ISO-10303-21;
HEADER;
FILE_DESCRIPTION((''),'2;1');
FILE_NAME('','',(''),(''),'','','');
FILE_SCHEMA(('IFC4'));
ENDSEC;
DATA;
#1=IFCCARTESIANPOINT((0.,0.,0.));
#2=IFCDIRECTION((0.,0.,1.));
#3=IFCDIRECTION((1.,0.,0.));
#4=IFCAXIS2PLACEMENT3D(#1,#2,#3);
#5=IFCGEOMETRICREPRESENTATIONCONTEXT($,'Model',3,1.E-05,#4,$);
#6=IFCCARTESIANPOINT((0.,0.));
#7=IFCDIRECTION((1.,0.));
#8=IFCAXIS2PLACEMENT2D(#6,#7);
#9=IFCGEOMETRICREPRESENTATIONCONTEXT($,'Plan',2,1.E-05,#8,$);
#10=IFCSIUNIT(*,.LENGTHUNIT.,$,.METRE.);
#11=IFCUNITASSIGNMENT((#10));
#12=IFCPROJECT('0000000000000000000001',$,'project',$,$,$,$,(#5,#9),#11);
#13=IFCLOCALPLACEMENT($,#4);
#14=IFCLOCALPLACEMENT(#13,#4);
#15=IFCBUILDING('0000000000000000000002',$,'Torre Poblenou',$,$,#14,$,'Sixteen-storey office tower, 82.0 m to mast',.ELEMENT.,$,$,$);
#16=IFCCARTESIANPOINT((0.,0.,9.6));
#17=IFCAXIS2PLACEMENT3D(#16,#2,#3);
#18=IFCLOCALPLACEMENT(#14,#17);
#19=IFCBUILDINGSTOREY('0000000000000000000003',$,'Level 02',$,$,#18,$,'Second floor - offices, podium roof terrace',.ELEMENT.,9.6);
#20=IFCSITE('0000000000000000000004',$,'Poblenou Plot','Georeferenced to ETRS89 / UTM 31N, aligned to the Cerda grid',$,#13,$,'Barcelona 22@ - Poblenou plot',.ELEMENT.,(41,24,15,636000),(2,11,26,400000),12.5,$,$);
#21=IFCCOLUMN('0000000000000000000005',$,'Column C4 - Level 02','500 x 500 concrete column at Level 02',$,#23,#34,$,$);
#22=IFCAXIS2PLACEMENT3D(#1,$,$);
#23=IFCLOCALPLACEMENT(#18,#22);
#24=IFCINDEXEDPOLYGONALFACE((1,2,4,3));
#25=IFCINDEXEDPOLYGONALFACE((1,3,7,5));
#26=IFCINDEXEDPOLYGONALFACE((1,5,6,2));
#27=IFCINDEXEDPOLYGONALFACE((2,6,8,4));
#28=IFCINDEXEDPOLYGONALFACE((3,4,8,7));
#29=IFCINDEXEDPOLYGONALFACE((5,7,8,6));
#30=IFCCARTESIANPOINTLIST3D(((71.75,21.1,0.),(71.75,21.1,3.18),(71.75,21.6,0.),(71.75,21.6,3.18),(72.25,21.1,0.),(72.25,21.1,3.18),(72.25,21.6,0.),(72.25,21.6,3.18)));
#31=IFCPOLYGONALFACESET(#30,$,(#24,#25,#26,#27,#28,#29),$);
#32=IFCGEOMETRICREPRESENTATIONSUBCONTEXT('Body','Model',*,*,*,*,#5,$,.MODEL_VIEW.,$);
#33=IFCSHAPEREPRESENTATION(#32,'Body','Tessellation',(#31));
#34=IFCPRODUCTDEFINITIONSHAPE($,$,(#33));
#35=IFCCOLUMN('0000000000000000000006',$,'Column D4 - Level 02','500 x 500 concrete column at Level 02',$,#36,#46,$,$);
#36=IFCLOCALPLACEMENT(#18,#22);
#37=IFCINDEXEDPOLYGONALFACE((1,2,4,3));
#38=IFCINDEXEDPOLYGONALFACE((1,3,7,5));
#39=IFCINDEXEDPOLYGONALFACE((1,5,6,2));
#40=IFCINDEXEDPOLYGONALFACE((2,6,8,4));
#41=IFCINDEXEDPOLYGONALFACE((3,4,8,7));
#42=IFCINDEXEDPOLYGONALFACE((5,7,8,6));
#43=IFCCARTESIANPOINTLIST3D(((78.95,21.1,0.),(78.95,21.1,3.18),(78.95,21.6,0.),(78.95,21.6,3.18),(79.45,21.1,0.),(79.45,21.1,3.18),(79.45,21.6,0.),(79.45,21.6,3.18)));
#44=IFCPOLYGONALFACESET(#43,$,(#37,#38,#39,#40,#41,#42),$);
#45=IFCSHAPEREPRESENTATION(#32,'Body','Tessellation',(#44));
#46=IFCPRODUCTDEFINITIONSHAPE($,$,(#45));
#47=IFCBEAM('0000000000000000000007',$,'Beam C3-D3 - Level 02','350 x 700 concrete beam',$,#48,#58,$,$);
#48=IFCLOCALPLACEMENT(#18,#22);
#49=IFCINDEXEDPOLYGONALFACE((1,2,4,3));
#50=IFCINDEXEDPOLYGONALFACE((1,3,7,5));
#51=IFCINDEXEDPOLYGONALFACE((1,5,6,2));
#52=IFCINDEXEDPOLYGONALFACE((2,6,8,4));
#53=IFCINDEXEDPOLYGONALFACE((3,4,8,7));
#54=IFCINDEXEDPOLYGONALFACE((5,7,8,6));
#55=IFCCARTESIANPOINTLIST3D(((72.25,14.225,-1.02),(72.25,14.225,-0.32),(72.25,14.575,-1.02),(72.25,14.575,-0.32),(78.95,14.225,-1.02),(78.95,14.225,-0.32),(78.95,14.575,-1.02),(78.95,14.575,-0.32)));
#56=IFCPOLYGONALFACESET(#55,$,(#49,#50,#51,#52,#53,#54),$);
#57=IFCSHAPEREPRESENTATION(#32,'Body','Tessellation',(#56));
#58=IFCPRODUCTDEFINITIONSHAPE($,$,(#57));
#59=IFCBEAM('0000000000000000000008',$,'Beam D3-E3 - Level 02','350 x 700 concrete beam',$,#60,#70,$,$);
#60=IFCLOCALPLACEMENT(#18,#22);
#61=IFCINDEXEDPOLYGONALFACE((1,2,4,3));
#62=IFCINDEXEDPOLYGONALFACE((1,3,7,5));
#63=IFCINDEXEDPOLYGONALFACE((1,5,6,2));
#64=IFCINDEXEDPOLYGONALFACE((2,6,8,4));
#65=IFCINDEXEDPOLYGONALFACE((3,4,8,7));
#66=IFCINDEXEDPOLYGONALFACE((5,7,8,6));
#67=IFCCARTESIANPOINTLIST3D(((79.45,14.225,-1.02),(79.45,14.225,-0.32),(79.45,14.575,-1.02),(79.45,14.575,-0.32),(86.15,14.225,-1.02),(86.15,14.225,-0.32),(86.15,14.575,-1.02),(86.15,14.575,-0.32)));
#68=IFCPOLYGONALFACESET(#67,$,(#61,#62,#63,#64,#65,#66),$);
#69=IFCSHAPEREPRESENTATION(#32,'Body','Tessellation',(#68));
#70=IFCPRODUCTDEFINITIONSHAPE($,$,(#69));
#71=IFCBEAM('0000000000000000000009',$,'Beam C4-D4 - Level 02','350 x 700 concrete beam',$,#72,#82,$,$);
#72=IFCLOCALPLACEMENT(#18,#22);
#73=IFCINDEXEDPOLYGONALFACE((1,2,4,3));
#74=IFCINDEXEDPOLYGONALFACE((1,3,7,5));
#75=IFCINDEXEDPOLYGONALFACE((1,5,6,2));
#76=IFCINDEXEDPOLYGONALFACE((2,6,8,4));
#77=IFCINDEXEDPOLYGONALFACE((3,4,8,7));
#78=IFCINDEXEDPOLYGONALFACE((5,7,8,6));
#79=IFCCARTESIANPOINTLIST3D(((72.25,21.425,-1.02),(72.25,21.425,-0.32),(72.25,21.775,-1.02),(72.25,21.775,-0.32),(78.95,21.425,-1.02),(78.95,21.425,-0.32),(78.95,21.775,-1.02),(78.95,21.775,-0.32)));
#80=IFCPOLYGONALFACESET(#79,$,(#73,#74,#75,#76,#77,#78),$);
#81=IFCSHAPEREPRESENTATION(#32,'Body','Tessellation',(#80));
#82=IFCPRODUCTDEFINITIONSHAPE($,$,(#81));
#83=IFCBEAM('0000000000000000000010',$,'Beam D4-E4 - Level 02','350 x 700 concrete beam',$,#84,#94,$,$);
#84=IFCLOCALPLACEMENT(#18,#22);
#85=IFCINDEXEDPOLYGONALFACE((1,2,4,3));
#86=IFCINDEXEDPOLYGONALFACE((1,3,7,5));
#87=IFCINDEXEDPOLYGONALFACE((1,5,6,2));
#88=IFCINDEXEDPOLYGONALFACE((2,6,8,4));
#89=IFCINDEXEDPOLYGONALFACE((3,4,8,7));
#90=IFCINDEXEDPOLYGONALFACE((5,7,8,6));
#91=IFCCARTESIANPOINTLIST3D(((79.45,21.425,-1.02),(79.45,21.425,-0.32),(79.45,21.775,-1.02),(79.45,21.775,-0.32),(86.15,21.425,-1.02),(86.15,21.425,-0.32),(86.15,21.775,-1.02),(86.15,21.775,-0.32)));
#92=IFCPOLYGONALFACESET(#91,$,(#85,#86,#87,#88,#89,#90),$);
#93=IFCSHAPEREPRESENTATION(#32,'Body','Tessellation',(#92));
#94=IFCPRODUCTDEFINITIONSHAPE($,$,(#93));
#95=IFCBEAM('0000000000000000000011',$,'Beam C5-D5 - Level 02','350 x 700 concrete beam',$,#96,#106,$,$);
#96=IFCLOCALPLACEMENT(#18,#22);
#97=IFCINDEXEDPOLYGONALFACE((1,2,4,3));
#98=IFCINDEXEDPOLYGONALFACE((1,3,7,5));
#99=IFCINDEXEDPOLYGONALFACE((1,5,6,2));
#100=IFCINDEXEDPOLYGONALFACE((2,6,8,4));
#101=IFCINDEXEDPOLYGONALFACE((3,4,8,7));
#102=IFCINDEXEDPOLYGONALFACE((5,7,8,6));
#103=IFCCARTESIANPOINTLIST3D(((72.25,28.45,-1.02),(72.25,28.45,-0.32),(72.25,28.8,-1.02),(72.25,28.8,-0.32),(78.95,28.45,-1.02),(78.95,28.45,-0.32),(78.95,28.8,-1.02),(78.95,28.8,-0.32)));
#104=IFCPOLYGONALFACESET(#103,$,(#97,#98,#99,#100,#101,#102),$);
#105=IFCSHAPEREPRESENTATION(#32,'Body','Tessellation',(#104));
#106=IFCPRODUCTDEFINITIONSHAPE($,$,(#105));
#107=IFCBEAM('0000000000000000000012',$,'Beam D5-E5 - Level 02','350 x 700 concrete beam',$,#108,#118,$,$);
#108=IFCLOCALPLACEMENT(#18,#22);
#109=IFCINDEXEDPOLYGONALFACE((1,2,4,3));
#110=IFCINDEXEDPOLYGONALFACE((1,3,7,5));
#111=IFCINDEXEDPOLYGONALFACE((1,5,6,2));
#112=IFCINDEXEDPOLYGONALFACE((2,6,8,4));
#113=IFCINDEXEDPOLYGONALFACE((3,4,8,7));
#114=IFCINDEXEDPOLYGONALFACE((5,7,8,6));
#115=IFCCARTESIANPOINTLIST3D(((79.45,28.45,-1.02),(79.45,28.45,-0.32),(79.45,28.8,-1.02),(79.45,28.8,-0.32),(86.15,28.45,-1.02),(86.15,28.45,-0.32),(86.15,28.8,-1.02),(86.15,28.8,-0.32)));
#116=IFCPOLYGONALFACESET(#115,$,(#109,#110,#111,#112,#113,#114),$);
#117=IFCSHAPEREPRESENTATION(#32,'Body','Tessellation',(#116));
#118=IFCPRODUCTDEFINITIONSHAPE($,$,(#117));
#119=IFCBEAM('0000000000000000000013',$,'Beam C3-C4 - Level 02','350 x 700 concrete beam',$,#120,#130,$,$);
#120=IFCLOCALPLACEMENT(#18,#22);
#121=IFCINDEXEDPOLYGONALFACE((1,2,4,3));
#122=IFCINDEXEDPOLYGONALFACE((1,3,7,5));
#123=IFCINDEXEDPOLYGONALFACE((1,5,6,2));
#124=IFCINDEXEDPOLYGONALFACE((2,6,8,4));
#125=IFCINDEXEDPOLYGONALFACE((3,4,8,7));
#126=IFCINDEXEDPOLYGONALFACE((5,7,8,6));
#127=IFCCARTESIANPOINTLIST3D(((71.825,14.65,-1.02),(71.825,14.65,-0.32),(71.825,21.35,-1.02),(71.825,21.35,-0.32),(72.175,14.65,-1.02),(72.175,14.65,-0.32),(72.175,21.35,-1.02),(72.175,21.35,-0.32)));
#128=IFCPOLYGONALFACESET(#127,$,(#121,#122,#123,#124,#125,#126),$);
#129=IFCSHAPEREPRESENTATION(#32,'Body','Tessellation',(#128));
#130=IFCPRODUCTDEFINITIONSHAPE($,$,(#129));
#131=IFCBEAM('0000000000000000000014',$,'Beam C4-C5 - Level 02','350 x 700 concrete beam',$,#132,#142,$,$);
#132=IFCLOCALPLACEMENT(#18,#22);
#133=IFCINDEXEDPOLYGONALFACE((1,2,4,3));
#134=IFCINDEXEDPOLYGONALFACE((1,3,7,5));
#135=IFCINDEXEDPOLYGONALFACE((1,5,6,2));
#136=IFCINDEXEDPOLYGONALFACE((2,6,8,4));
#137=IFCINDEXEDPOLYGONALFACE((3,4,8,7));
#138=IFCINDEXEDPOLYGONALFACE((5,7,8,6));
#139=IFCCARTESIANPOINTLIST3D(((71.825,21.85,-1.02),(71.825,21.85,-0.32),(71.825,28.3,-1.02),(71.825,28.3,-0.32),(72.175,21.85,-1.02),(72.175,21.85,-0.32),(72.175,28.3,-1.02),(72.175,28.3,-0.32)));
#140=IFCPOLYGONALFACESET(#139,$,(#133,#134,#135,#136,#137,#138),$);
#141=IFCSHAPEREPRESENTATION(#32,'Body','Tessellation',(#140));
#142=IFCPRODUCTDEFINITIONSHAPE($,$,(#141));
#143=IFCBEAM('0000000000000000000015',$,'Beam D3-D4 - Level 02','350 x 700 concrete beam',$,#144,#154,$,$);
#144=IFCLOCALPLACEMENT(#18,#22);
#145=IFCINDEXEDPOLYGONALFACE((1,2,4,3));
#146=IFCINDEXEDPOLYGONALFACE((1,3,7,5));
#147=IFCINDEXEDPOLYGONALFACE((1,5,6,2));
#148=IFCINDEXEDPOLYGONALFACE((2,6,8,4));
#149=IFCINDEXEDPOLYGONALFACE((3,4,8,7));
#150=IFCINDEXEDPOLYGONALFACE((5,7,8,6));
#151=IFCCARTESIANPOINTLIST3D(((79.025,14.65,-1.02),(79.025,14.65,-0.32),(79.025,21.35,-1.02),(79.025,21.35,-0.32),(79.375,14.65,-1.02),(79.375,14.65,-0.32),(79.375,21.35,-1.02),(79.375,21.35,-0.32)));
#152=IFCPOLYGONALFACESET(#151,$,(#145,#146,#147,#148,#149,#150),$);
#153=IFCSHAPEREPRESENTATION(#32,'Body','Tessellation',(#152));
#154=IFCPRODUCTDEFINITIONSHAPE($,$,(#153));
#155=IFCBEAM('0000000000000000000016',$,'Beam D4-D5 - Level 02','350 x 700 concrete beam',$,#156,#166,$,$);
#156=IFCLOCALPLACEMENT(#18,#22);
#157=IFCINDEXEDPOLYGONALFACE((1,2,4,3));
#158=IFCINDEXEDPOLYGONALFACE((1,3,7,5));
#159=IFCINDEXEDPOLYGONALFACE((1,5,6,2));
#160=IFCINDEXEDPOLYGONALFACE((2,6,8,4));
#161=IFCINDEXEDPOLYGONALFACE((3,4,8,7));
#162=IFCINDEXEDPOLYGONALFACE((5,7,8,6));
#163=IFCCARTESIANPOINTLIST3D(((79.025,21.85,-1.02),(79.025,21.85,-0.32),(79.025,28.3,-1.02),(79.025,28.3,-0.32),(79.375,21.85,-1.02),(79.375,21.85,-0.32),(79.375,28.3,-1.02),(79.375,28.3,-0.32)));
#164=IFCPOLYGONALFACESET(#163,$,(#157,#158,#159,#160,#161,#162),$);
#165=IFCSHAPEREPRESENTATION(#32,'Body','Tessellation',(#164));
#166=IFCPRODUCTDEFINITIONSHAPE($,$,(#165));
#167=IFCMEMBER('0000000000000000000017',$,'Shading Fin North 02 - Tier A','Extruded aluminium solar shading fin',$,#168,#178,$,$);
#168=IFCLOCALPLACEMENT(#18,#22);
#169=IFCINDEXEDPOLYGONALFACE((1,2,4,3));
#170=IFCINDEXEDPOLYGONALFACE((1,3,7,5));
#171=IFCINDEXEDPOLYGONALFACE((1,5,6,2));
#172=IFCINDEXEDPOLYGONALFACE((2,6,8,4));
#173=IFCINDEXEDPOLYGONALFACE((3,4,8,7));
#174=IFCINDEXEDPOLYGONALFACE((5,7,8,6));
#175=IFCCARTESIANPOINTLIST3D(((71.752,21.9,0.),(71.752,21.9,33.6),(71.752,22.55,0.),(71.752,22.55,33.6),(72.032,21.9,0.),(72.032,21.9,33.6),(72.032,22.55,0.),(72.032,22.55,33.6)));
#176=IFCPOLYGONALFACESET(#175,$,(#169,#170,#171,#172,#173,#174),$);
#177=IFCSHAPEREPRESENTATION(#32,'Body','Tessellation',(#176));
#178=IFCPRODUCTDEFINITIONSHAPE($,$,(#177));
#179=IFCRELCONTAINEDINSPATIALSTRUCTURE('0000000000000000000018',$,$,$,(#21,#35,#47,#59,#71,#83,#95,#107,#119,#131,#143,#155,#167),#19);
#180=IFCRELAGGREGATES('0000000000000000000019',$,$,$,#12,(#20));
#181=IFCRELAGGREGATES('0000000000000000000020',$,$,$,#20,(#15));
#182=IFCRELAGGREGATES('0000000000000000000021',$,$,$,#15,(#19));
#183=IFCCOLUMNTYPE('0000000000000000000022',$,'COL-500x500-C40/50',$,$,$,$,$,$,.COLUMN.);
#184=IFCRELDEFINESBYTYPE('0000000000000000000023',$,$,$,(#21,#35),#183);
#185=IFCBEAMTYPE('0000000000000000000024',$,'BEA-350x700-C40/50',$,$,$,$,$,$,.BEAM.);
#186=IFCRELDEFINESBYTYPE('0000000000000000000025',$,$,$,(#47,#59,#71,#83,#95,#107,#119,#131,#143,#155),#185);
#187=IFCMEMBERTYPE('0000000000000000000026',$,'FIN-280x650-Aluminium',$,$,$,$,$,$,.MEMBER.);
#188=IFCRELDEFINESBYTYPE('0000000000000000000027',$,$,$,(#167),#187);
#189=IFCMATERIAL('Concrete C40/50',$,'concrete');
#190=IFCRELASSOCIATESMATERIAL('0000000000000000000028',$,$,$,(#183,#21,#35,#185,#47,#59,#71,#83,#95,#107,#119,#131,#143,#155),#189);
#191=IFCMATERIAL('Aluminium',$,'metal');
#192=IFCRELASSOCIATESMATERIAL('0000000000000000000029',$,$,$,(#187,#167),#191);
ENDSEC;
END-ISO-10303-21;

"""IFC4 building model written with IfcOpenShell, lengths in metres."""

from ifc_helpers import new_model, si_unit, frame, origin_with_axes, origin_2d_with_axis, place, context, subcontext, project, spatial, line, indexed_curve, rectangle, outline, extrude, material, material_profile, profile_set, profile_usage, type_object, element, save


model = new_model("IFC4")

# Units and contexts
model_context = context("Model", 3, precision=1e-05, world=origin_with_axes())
plan_context = context("Plan", 2, precision=1e-05, world=origin_2d_with_axis())
body_context = subcontext(model_context, "Body", "Model", "MODEL_VIEW")
ifc_project = project(units=[si_unit("LENGTHUNIT", "METRE")], contexts=[model_context, plan_context])

# Site, building, storey
site_placement = place(None, origin_with_axes())
site = spatial("IfcSite", under=ifc_project, at=site_placement, Name="Poblenou Plot", Description="Georeferenced to ETRS89 / UTM 31N, aligned to the Cerda grid", LongName="Barcelona 22@ - Poblenou plot", CompositionType="ELEMENT", RefLatitude=(41, 24, 15, 636000), RefLongitude=(2, 11, 26, 400000), RefElevation=12.5)
building_placement = place(site_placement, origin_with_axes())
building = spatial("IfcBuilding", under=site, at=building_placement, Name="Torre Poblenou", LongName="Sixteen-storey office tower, 82.0 m to mast", CompositionType="ELEMENT")
storey_placement = place(building_placement, frame((0.0, 0.0, 9.6), z_axis=(0.0, 0.0, 1.0), x_axis=(1.0, 0.0, 0.0)))
storey = spatial("IfcBuildingStorey", under=building, at=storey_placement, Name="Level 02", LongName="Second floor - offices, podium roof terrace", CompositionType="ELEMENT", Elevation=9.6)

# Columns
ifc_material_1 = material(Name="Concrete C40/50", Category="concrete")
ifc_material_profile_1 = material_profile(ifc_material_1, rectangle(XDim=0.5, YDim=0.5))
ifc_profile_set_1 = profile_set([ifc_material_profile_1], Name="COL-500x500-C40/50")
ifc_profile_usage_1 = profile_usage(ifc_profile_set_1)
column_type = type_object("IfcColumnType", Name="COL-500x500-C40/50", PredefinedType="COLUMN", material=ifc_profile_set_1)
column_1_placement = place(storey_placement, frame((71.75, 21.1, 0.0), z_axis=(0.0, 0.0, 1.0), x_axis=(1.0, 0.0, 0.0)))
element("IfcColumn", 1, at=column_1_placement, inside=storey, type_object=column_type, material=ifc_profile_usage_1, Name="Column C4 - Level 02", Description="500 x 500 concrete column at Level 02", context=body_context, shape_type="SweptSolid", body=[
    extrude(outline(indexed_curve([(0.0, 0.0), (0.5, 0.0), (0.5, 0.5), (0.0, 0.5)], segments=[line(1, 2, 3, 4, 1)])), origin_with_axes(), (0.0, 0.0, 1.0), 3.18),
])
ifc_profile_usage_2 = profile_usage(ifc_profile_set_1)
column_2_placement = place(storey_placement, frame((78.95, 21.1, 0.0), z_axis=(0.0, 0.0, 1.0), x_axis=(1.0, 0.0, 0.0)))
element("IfcColumn", 2, at=column_2_placement, inside=storey, type_object=column_type, material=ifc_profile_usage_2, Name="Column D4 - Level 02", Description="500 x 500 concrete column at Level 02", context=body_context, shape_type="SweptSolid", body=[
    extrude(outline(indexed_curve([(0.0, 0.0), (0.5, 0.0), (0.5, 0.5), (0.0, 0.5)], segments=[line(1, 2, 3, 4, 1)])), origin_with_axes(), (0.0, 0.0, 1.0), 3.18),
])

# Beams
ifc_material_profile_2 = material_profile(ifc_material_1, rectangle(XDim=0.35, YDim=0.7))
ifc_profile_set_2 = profile_set([ifc_material_profile_2], Name="BEA-350x700-C40/50")
ifc_profile_usage_3 = profile_usage(ifc_profile_set_2)
beam_type = type_object("IfcBeamType", Name="BEA-350x700-C40/50", PredefinedType="BEAM", material=ifc_profile_set_2)
beam_1_placement = place(storey_placement, frame((72.25, 14.225, -1.02), z_axis=(0.0, 0.0, 1.0), x_axis=(1.0, 0.0, 0.0)))
element("IfcBeam", 3, at=beam_1_placement, inside=storey, type_object=beam_type, material=ifc_profile_usage_3, Name="Beam C3-D3 - Level 02", Description="350 x 700 concrete beam", context=body_context, shape_type="SweptSolid", body=[
    extrude(outline(indexed_curve([(0.0, 0.0), (6.7, 0.0), (6.7, 0.35), (0.0, 0.35)], segments=[line(1, 2, 3, 4, 1)])), origin_with_axes(), (0.0, 0.0, 1.0), 0.7),
])
ifc_profile_usage_4 = profile_usage(ifc_profile_set_2)
beam_2_placement = place(storey_placement, frame((79.45, 14.225, -1.02), z_axis=(0.0, 0.0, 1.0), x_axis=(1.0, 0.0, 0.0)))
element("IfcBeam", 4, at=beam_2_placement, inside=storey, type_object=beam_type, material=ifc_profile_usage_4, Name="Beam D3-E3 - Level 02", Description="350 x 700 concrete beam", context=body_context, shape_type="SweptSolid", body=[
    extrude(outline(indexed_curve([(0.0, 0.0), (6.7, 0.0), (6.7, 0.35), (0.0, 0.35)], segments=[line(1, 2, 3, 4, 1)])), origin_with_axes(), (0.0, 0.0, 1.0), 0.7),
])
ifc_profile_usage_5 = profile_usage(ifc_profile_set_2)
beam_3_placement = place(storey_placement, frame((72.25, 21.425, -1.02), z_axis=(0.0, 0.0, 1.0), x_axis=(1.0, 0.0, 0.0)))
element("IfcBeam", 5, at=beam_3_placement, inside=storey, type_object=beam_type, material=ifc_profile_usage_5, Name="Beam C4-D4 - Level 02", Description="350 x 700 concrete beam", context=body_context, shape_type="SweptSolid", body=[
    extrude(outline(indexed_curve([(0.0, 0.0), (6.7, 0.0), (6.7, 0.35), (0.0, 0.35)], segments=[line(1, 2, 3, 4, 1)])), origin_with_axes(), (0.0, 0.0, 1.0), 0.7),
])
ifc_profile_usage_6 = profile_usage(ifc_profile_set_2)
beam_4_placement = place(storey_placement, frame((79.45, 21.425, -1.02), z_axis=(0.0, 0.0, 1.0), x_axis=(1.0, 0.0, 0.0)))
element("IfcBeam", 6, at=beam_4_placement, inside=storey, type_object=beam_type, material=ifc_profile_usage_6, Name="Beam D4-E4 - Level 02", Description="350 x 700 concrete beam", context=body_context, shape_type="SweptSolid", body=[
    extrude(outline(indexed_curve([(0.0, 0.0), (6.7, 0.0), (6.7, 0.35), (0.0, 0.35)], segments=[line(1, 2, 3, 4, 1)])), origin_with_axes(), (0.0, 0.0, 1.0), 0.7),
])
ifc_profile_usage_7 = profile_usage(ifc_profile_set_2)
beam_5_placement = place(storey_placement, frame((72.25, 28.45, -1.02), z_axis=(0.0, 0.0, 1.0), x_axis=(1.0, 0.0, 0.0)))
element("IfcBeam", 7, at=beam_5_placement, inside=storey, type_object=beam_type, material=ifc_profile_usage_7, Name="Beam C5-D5 - Level 02", Description="350 x 700 concrete beam", context=body_context, shape_type="SweptSolid", body=[
    extrude(outline(indexed_curve([(0.0, 0.0), (6.7, 0.0), (6.7, 0.35), (0.0, 0.35)], segments=[line(1, 2, 3, 4, 1)])), origin_with_axes(), (0.0, 0.0, 1.0), 0.7),
])
ifc_profile_usage_8 = profile_usage(ifc_profile_set_2)
beam_6_placement = place(storey_placement, frame((79.45, 28.45, -1.02), z_axis=(0.0, 0.0, 1.0), x_axis=(1.0, 0.0, 0.0)))
element("IfcBeam", 8, at=beam_6_placement, inside=storey, type_object=beam_type, material=ifc_profile_usage_8, Name="Beam D5-E5 - Level 02", Description="350 x 700 concrete beam", context=body_context, shape_type="SweptSolid", body=[
    extrude(outline(indexed_curve([(0.0, 0.0), (6.7, 0.0), (6.7, 0.35), (0.0, 0.35)], segments=[line(1, 2, 3, 4, 1)])), origin_with_axes(), (0.0, 0.0, 1.0), 0.7),
])
ifc_profile_usage_9 = profile_usage(ifc_profile_set_2)
beam_7_placement = place(storey_placement, frame((72.175, 14.65, -1.02), z_axis=(0.0, 0.0, 1.0), x_axis=(0.0, 1.0, 0.0)))
element("IfcBeam", 9, at=beam_7_placement, inside=storey, type_object=beam_type, material=ifc_profile_usage_9, Name="Beam C3-C4 - Level 02", Description="350 x 700 concrete beam", context=body_context, shape_type="SweptSolid", body=[
    extrude(outline(indexed_curve([(0.0, 0.0), (6.7, 0.0), (6.7, 0.35), (0.0, 0.35)], segments=[line(1, 2, 3, 4, 1)])), origin_with_axes(), (0.0, 0.0, 1.0), 0.7),
])
ifc_profile_usage_10 = profile_usage(ifc_profile_set_2)
beam_8_placement = place(storey_placement, frame((72.175, 21.85, -1.02), z_axis=(0.0, 0.0, 1.0), x_axis=(0.0, 1.0, 0.0)))
element("IfcBeam", 10, at=beam_8_placement, inside=storey, type_object=beam_type, material=ifc_profile_usage_10, Name="Beam C4-C5 - Level 02", Description="350 x 700 concrete beam", context=body_context, shape_type="SweptSolid", body=[
    extrude(outline(indexed_curve([(0.0, 0.0), (6.45, 0.0), (6.45, 0.35), (0.0, 0.35)], segments=[line(1, 2, 3, 4, 1)])), origin_with_axes(), (0.0, 0.0, 1.0), 0.7),
])
ifc_profile_usage_11 = profile_usage(ifc_profile_set_2)
beam_9_placement = place(storey_placement, frame((79.375, 14.65, -1.02), z_axis=(0.0, 0.0, 1.0), x_axis=(0.0, 1.0, 0.0)))
element("IfcBeam", 11, at=beam_9_placement, inside=storey, type_object=beam_type, material=ifc_profile_usage_11, Name="Beam D3-D4 - Level 02", Description="350 x 700 concrete beam", context=body_context, shape_type="SweptSolid", body=[
    extrude(outline(indexed_curve([(0.0, 0.0), (6.7, 0.0), (6.7, 0.35), (0.0, 0.35)], segments=[line(1, 2, 3, 4, 1)])), origin_with_axes(), (0.0, 0.0, 1.0), 0.7),
])
ifc_profile_usage_12 = profile_usage(ifc_profile_set_2)
beam_10_placement = place(storey_placement, frame((79.375, 21.85, -1.02), z_axis=(0.0, 0.0, 1.0), x_axis=(0.0, 1.0, 0.0)))
element("IfcBeam", 12, at=beam_10_placement, inside=storey, type_object=beam_type, material=ifc_profile_usage_12, Name="Beam D4-D5 - Level 02", Description="350 x 700 concrete beam", context=body_context, shape_type="SweptSolid", body=[
    extrude(outline(indexed_curve([(0.0, 0.0), (6.45, 0.0), (6.45, 0.35), (0.0, 0.35)], segments=[line(1, 2, 3, 4, 1)])), origin_with_axes(), (0.0, 0.0, 1.0), 0.7),
])

# Member
ifc_material_2 = material(Name="Aluminium", Category="metal")
ifc_material_profile_3 = material_profile(ifc_material_2, rectangle(XDim=0.28, YDim=0.65))
ifc_profile_set_3 = profile_set([ifc_material_profile_3], Name="FIN-280x650-Aluminium")
ifc_profile_usage_13 = profile_usage(ifc_profile_set_3)
member_type = type_object("IfcMemberType", Name="FIN-280x650-Aluminium", PredefinedType="MEMBER", material=ifc_profile_set_3)
member_1_placement = place(storey_placement, frame((71.752, 21.9, 0.0), z_axis=(0.0, 0.0, 1.0), x_axis=(1.0, 0.0, 0.0)))
element("IfcMember", 13, at=member_1_placement, inside=storey, type_object=member_type, material=ifc_profile_usage_13, Name="Shading Fin North 02 - Tier A", Description="Extruded aluminium solar shading fin", context=body_context, shape_type="SweptSolid", body=[
    extrude(outline(indexed_curve([(0.0, 0.0), (0.28, 0.0), (0.28, 0.65), (0.0, 0.65)], segments=[line(1, 2, 3, 4, 1)])), origin_with_axes(), (0.0, 0.0, 1.0), 33.6),
])

save(model, "model.ifc")
